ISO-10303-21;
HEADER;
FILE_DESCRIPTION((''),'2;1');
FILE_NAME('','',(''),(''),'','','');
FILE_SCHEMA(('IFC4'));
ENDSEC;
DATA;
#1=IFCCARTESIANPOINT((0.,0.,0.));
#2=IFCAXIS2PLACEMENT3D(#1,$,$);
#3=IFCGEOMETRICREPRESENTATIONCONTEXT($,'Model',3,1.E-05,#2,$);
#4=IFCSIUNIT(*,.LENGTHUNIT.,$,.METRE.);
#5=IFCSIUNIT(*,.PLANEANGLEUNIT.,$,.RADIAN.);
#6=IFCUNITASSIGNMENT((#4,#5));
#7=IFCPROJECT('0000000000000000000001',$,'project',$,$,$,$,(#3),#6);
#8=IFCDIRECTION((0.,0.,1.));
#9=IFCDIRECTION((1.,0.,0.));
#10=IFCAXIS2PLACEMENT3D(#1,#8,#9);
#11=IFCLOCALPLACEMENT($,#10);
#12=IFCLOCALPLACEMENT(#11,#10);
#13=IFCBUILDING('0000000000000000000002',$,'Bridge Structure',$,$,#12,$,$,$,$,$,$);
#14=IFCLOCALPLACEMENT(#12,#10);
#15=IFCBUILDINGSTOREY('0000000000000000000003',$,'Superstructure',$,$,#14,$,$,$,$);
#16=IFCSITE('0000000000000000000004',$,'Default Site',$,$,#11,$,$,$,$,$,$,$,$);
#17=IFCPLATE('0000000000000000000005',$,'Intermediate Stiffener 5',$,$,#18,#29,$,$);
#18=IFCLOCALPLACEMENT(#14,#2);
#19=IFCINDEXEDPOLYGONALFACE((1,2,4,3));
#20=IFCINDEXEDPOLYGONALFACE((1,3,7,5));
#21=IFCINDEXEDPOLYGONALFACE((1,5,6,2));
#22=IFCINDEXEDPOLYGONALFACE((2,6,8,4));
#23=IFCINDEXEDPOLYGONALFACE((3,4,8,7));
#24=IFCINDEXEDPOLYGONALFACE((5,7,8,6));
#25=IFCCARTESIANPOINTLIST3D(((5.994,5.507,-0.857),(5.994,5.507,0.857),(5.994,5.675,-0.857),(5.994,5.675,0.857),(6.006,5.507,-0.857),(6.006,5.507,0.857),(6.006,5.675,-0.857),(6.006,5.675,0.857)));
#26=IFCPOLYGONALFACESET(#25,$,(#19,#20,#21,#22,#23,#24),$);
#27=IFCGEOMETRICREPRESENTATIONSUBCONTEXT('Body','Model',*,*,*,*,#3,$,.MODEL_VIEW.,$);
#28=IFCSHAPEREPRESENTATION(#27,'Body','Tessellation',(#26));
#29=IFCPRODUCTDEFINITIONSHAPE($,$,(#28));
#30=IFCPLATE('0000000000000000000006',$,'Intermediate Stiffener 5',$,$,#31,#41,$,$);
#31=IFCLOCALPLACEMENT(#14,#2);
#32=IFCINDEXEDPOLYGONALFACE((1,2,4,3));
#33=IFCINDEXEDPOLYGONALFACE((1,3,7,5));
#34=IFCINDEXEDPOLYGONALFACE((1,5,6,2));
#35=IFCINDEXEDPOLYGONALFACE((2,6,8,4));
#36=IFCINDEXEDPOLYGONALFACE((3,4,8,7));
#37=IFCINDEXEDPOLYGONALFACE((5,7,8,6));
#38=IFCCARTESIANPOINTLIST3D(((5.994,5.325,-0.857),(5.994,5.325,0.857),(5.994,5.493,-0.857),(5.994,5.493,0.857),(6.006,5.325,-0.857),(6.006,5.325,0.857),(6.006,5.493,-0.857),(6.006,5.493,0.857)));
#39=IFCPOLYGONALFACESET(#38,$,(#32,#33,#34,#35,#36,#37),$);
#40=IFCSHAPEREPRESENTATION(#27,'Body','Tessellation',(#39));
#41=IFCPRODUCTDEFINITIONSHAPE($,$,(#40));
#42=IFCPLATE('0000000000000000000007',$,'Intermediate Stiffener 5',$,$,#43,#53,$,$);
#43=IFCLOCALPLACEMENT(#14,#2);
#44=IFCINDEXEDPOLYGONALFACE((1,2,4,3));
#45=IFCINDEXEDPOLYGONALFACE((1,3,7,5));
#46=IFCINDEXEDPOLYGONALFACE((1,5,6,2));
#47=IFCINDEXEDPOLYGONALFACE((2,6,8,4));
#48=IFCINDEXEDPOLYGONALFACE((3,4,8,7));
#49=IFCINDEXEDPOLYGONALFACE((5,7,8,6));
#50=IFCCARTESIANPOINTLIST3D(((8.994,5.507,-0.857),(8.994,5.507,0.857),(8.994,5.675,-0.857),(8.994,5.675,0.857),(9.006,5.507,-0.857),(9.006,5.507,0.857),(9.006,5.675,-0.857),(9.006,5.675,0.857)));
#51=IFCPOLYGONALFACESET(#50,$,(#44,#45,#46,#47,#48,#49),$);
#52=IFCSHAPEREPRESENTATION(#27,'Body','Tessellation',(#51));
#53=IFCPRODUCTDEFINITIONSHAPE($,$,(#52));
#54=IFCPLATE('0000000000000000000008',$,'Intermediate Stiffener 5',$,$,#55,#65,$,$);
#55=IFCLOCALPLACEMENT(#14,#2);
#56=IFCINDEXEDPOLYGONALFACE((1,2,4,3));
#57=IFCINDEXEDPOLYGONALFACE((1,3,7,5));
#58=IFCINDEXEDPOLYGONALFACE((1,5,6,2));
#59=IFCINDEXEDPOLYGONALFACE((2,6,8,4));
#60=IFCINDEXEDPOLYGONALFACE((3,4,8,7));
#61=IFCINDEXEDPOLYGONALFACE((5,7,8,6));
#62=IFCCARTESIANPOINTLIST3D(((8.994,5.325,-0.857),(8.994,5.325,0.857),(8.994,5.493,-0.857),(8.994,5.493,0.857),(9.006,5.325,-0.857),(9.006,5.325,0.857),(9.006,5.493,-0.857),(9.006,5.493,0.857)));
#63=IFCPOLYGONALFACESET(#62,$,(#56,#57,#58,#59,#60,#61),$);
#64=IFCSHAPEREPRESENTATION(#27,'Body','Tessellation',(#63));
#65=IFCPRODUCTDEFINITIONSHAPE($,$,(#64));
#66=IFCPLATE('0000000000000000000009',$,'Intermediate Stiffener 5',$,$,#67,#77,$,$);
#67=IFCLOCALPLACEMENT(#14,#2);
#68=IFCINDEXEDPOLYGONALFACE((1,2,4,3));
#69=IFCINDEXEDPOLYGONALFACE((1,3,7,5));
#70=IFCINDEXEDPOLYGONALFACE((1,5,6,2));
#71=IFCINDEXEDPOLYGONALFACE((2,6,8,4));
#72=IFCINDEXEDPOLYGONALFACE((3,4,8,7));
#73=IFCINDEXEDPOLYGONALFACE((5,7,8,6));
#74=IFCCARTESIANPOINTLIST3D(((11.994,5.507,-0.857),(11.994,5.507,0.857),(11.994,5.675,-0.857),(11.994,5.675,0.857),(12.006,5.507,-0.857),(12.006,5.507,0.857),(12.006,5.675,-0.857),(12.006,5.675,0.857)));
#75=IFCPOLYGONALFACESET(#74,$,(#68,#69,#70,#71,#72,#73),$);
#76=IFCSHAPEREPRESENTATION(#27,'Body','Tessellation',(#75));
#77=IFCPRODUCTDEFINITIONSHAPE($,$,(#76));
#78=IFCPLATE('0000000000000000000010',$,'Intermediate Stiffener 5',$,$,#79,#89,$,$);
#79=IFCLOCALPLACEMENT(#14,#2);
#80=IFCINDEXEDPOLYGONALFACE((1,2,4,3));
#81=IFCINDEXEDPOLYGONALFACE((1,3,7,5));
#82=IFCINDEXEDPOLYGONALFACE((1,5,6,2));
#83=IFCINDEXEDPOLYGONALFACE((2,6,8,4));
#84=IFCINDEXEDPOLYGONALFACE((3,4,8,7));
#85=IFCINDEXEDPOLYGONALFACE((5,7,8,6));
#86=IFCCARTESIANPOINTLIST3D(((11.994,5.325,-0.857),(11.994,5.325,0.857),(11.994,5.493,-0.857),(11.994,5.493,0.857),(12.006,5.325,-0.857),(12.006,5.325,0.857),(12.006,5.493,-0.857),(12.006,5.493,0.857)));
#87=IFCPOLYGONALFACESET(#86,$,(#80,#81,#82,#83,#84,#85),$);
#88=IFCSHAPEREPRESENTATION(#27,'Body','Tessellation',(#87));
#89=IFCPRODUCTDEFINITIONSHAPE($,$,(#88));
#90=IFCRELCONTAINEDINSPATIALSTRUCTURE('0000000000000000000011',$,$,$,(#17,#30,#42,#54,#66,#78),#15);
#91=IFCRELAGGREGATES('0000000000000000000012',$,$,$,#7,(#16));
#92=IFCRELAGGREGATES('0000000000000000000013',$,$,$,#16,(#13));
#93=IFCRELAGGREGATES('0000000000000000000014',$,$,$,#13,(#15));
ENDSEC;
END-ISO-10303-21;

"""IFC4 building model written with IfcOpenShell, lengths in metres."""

from ifc_helpers import new_model, si_unit, frame, origin, origin_with_axes, origin_2d_with_axis, place, context, subcontext, project, spatial, rectangle, extrude, element, save


model = new_model("IFC4")

# Units and contexts
model_context = context("Model", 3, precision=1e-05, world=origin())
body_context = subcontext(model_context, "Body", "Model", "MODEL_VIEW")
ifc_project = project(units=[si_unit("LENGTHUNIT", "METRE"), si_unit("PLANEANGLEUNIT", "RADIAN")], contexts=[model_context])

# Site, building, storey
site_placement = place(None, origin_with_axes())
site = spatial("IfcSite", under=ifc_project, at=site_placement, Name="Default Site")
building_placement = place(site_placement, origin_with_axes())
building = spatial("IfcBuilding", under=site, at=building_placement, Name="Bridge Structure")
storey_placement = place(building_placement, origin_with_axes())
storey = spatial("IfcBuildingStorey", under=building, at=storey_placement, Name="Superstructure")

# Plates
for number, where, z_axis, x_axis, name in (
    (1, (6.0, 5.591, -0.857), (0.0, 0.0, 1.0), (1.0, 0.0, 0.0), "Intermediate Stiffener 5"),
    (2, (6.0, 5.409, -0.857), (0.0, 0.0, 1.0), (1.0, 0.0, 0.0), "Intermediate Stiffener 5"),
    (3, (9.0, 5.591, -0.857), (0.0, 0.0, 1.0), (1.0, 0.0, 0.0), "Intermediate Stiffener 5"),
    (4, (9.0, 5.409, -0.857), (0.0, 0.0, 1.0), (1.0, 0.0, 0.0), "Intermediate Stiffener 5"),
    (5, (12.0, 5.591, -0.857), (0.0, 0.0, 1.0), (1.0, 0.0, 0.0), "Intermediate Stiffener 5"),
    (6, (12.0, 5.409, -0.857), (0.0, 0.0, 1.0), (1.0, 0.0, 0.0), "Intermediate Stiffener 5"),
):
    element("IfcPlate", number, at=place(storey_placement, frame(where, z_axis=z_axis, x_axis=x_axis)), inside=storey, Name=name, context=body_context, shape_type="SweptSolid", body=[
        extrude(rectangle(XDim=0.012, YDim=0.168, at=origin_2d_with_axis()), origin_with_axes(), (0.0, 0.0, 1.0), 1.714),
    ])

save(model, "model.ifc")
